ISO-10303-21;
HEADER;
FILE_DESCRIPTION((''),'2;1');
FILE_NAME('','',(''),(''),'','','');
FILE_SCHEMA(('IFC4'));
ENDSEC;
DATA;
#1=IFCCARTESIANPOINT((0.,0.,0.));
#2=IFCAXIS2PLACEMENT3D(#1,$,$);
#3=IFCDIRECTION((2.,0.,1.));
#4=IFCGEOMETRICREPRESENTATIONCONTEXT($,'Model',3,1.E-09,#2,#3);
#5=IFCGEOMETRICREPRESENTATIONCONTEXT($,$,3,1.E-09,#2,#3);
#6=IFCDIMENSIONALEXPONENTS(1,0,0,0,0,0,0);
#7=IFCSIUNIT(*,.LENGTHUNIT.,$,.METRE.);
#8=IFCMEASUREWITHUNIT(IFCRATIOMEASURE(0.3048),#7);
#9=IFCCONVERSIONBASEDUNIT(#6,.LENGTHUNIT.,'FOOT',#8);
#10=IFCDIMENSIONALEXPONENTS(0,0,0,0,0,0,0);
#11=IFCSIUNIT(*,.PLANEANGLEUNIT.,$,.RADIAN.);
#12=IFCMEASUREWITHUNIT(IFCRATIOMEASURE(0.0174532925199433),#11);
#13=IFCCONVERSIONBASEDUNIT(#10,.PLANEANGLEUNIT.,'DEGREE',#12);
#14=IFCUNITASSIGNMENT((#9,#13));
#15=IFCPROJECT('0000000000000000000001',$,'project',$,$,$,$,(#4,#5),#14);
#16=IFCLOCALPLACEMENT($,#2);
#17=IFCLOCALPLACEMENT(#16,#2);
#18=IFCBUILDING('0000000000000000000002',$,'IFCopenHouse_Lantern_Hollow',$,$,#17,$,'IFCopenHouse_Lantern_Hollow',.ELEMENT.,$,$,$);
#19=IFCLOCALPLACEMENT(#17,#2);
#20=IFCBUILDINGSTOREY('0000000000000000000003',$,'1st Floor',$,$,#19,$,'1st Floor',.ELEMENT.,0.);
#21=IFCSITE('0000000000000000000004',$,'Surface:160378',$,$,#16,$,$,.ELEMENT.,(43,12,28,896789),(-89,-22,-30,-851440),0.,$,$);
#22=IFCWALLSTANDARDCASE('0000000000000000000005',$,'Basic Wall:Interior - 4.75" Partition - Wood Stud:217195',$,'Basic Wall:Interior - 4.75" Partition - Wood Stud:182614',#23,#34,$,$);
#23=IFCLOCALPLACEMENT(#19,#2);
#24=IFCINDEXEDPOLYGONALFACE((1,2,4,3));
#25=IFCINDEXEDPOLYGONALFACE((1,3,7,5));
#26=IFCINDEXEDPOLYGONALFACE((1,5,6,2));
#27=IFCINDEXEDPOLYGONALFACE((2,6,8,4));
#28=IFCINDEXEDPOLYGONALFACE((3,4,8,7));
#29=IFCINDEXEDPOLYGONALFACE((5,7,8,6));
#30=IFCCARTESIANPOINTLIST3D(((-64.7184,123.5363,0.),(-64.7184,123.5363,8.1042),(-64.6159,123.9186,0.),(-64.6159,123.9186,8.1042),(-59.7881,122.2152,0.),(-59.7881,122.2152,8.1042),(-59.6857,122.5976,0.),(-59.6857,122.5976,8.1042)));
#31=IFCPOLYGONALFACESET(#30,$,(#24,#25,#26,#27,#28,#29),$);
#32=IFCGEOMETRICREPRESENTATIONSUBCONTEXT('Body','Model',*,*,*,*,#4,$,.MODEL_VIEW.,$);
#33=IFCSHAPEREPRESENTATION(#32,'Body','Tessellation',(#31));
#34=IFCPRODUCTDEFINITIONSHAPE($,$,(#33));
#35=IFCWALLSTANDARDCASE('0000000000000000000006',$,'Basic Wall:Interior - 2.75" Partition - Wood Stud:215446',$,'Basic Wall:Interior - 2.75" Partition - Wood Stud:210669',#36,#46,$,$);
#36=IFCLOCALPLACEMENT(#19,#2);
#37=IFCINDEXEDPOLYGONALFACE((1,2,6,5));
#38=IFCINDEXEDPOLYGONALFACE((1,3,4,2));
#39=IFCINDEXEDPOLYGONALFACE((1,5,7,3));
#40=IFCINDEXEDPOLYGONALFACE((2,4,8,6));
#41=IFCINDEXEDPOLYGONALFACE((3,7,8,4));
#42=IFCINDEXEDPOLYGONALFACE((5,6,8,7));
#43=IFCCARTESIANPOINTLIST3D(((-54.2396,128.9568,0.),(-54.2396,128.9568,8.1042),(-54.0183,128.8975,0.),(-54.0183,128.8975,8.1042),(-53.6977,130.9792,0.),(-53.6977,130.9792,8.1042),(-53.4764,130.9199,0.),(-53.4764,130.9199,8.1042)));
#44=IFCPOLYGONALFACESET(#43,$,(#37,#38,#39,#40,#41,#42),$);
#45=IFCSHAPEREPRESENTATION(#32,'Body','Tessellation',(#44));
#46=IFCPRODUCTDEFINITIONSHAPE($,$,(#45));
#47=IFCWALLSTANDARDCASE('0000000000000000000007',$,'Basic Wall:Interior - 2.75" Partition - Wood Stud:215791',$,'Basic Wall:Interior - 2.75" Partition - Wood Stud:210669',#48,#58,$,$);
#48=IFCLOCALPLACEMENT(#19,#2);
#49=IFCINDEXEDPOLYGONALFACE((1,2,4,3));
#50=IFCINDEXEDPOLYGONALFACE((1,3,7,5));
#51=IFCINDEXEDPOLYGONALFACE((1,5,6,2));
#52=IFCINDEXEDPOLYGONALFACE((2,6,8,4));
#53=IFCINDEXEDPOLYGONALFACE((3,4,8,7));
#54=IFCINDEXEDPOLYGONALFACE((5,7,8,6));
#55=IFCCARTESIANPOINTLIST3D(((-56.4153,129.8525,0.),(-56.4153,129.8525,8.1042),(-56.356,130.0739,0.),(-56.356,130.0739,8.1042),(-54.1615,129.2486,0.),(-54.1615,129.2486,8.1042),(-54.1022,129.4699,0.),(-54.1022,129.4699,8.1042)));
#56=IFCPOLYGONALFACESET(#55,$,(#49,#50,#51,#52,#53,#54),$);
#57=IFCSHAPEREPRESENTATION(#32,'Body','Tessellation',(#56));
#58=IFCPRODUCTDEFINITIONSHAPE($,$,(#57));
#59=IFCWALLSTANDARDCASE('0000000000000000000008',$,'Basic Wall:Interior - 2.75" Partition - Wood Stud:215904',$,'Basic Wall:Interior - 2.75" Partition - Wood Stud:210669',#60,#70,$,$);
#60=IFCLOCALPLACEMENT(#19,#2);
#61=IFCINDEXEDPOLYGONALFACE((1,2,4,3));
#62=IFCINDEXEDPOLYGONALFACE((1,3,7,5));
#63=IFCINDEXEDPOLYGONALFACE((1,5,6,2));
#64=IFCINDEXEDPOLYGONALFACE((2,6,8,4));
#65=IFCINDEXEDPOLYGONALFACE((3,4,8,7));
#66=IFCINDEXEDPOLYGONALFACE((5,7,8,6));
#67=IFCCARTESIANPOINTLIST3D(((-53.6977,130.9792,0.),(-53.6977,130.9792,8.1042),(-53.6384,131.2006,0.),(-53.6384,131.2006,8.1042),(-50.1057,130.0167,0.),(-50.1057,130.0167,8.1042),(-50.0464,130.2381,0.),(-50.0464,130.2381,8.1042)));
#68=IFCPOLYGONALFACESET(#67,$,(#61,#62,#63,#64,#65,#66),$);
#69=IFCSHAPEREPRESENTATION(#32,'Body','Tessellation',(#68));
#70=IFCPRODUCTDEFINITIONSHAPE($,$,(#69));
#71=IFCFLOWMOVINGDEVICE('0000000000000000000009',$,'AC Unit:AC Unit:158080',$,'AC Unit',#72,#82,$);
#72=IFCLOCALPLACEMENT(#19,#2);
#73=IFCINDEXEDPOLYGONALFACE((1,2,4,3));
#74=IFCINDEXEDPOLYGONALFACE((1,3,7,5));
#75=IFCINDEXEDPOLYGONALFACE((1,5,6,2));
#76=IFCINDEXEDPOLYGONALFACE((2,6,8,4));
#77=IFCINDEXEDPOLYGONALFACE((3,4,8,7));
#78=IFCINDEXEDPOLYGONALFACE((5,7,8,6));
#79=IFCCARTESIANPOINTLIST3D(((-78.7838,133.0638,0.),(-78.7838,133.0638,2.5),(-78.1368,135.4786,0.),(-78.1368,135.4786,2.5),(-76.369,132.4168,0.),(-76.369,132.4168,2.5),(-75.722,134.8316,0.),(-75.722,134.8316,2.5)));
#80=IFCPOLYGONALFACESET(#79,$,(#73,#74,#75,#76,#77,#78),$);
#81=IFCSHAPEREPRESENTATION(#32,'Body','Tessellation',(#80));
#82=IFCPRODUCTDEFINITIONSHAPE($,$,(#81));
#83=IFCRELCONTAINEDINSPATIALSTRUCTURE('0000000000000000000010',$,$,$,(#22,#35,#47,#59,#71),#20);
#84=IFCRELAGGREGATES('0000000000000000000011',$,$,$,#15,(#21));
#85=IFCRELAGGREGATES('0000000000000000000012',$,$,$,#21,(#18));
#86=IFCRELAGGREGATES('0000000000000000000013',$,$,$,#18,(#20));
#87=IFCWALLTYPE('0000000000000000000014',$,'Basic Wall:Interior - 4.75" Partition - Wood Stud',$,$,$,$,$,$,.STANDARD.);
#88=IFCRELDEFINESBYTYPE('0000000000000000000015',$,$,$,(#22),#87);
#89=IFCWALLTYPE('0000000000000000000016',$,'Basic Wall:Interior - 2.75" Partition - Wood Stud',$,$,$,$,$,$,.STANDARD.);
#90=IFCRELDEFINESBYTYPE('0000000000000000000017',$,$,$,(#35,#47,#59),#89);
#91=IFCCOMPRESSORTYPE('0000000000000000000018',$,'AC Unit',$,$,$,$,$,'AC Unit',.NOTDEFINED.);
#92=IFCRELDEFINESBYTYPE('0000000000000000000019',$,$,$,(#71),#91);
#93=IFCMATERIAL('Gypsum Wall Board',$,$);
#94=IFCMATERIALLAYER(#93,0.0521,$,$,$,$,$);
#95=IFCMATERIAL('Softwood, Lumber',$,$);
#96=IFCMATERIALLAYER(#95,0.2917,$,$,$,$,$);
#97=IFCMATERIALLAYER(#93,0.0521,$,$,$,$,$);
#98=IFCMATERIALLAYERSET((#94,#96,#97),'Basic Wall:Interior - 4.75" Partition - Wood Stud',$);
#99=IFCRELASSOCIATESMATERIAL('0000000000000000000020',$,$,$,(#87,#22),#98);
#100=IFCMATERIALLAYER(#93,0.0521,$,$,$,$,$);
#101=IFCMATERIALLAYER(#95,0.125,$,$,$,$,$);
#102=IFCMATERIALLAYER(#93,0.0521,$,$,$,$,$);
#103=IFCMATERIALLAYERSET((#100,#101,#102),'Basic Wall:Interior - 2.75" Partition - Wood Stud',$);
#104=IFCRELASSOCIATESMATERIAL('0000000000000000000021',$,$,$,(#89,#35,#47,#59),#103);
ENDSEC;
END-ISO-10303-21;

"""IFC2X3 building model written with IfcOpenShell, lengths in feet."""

from ifc_helpers import new_model, entity, si_unit, converted_unit, direction, frame, frame_2d, origin, place, context, subcontext, project, spatial, rectangle, extrude, source, transform, mapped, material, layer, layer_set, layer_usage, type_object, type_shapes, element, save


model = new_model("IFC2X3")

# Units and contexts
model_context = context("Model", 3, precision=1e-09, world=origin(), true_north=direction((2.0, 0.0, 1.0)))
context_of_model = context(None, 3, precision=1e-09, world=origin(), true_north=direction((2.0, 0.0, 1.0)))
body_context = subcontext(model_context, "Body", "Model", "MODEL_VIEW")
ifc_project = project(units=[converted_unit("LENGTHUNIT", "FOOT", entity("IfcRatioMeasure", 0.3048), si_unit("LENGTHUNIT", "METRE"), dimensions=[1, 0, 0, 0, 0, 0, 0]), converted_unit("PLANEANGLEUNIT", "DEGREE", entity("IfcRatioMeasure", 0.0174532925199433), si_unit("PLANEANGLEUNIT", "RADIAN"), dimensions=[0, 0, 0, 0, 0, 0, 0])], contexts=[model_context, context_of_model])

# Site, building, storey
site_placement = place(None, origin())
site = spatial("IfcSite", under=ifc_project, at=site_placement, Name="Surface:160378", CompositionType="ELEMENT", RefLatitude=(43, 12, 28, 896789), RefLongitude=(-89, -22, -30, -851440), RefElevation=0.0)
building_placement = place(site_placement, origin())
building = spatial("IfcBuilding", under=site, at=building_placement, Name="IFCopenHouse_Lantern_Hollow", LongName="IFCopenHouse_Lantern_Hollow", CompositionType="ELEMENT")
storey_placement = place(building_placement, origin())
storey = spatial("IfcBuildingStorey", under=building, at=storey_placement, Name="1st Floor", LongName="1st Floor", CompositionType="ELEMENT", Elevation=0.0)

# Shared definitions
ifc_material_1 = material(Name="Softwood, Lumber")

# Shared definitions
ifc_material_2 = material(Name="Gypsum Wall Board")

# Shared definitions
ifc_layer_1 = layer(ifc_material_2, 0.0521)
ifc_layer_2 = layer(ifc_material_1, 0.2917)
ifc_layer_3 = layer(ifc_material_2, 0.0521)
ifc_layer_set_1 = layer_set([ifc_layer_1, ifc_layer_2, ifc_layer_3], Name="Basic Wall:Interior - 4.75\" Partition - Wood Stud")
wall_type_1 = type_object("IfcWallType", Name="Basic Wall:Interior - 4.75\" Partition - Wood Stud", PredefinedType="STANDARD", material=ifc_layer_set_1)

# Walls
ifc_layer_usage_1 = layer_usage(ifc_layer_set_1, "AXIS2", "NEGATIVE", 0.1979)
wall_1_placement = place(storey_placement, frame((-59.7369, 122.4064, 0.0), z_axis=(0.0, 0.0, 1.0), x_axis=(-0.965926, 0.258819, 0.0)))
element("IfcWallStandardCase", 1, at=wall_1_placement, inside=storey, type_object=wall_type_1, material=ifc_layer_usage_1, Name="Basic Wall:Interior - 4.75\" Partition - Wood Stud:217195", ObjectType="Basic Wall:Interior - 4.75\" Partition - Wood Stud:182614", context=body_context, shape_type="SweptSolid", body=[
    extrude(rectangle(XDim=5.1042, YDim=0.3958, at=frame_2d((2.5521, 0.0), x_axis=(-1.0, 0.0))), origin(), (0.0, 0.0, 1.0), 8.1042),
])
ifc_layer_4 = layer(ifc_material_2, 0.0521)
ifc_layer_5 = layer(ifc_material_1, 0.125)
ifc_layer_6 = layer(ifc_material_2, 0.0521)
ifc_layer_set_2 = layer_set([ifc_layer_4, ifc_layer_5, ifc_layer_6], Name="Basic Wall:Interior - 2.75\" Partition - Wood Stud")
ifc_layer_usage_2 = layer_usage(ifc_layer_set_2, "AXIS2", "NEGATIVE", 0.1146)
wall_type_2 = type_object("IfcWallType", Name="Basic Wall:Interior - 2.75\" Partition - Wood Stud", PredefinedType="STANDARD", material=ifc_layer_set_2)
wall_2_placement = place(storey_placement, frame((-54.129, 128.9271, 0.0), z_axis=(0.0, 0.0, 1.0), x_axis=(0.258819, 0.965926, 0.0)))
element("IfcWallStandardCase", 2, at=wall_2_placement, inside=storey, type_object=wall_type_2, material=ifc_layer_usage_2, Name="Basic Wall:Interior - 2.75\" Partition - Wood Stud:215446", ObjectType="Basic Wall:Interior - 2.75\" Partition - Wood Stud:210669", context=body_context, shape_type="SweptSolid", body=[
    extrude(rectangle(XDim=2.0937, YDim=0.2292, at=frame_2d((1.0469, 0.0), x_axis=(-1.0, 0.0))), origin(), (0.0, 0.0, 1.0), 8.1042),
])
ifc_layer_usage_3 = layer_usage(ifc_layer_set_2, "AXIS2", "NEGATIVE", 0.1146)
wall_3_placement = place(storey_placement, frame((-56.3856, 129.9632, 0.0), z_axis=(0.0, 0.0, 1.0), x_axis=(0.965926, -0.258819, 0.0)))
element("IfcWallStandardCase", 3, at=wall_3_placement, inside=storey, type_object=wall_type_2, material=ifc_layer_usage_3, Name="Basic Wall:Interior - 2.75\" Partition - Wood Stud:215791", ObjectType="Basic Wall:Interior - 2.75\" Partition - Wood Stud:210669", context=body_context, shape_type="SweptSolid", body=[
    extrude(rectangle(XDim=2.3333, YDim=0.2292, at=frame_2d((1.1667, 0.0), x_axis=(-1.0, 0.0))), origin(), (0.0, 0.0, 1.0), 8.1042),
])
ifc_layer_usage_4 = layer_usage(ifc_layer_set_2, "AXIS2", "NEGATIVE", 0.1146)
wall_4_placement = place(storey_placement, frame((-53.6681, 131.0899, 0.0), z_axis=(0.0, 0.0, 1.0), x_axis=(0.965926, -0.258819, 0.0)))
element("IfcWallStandardCase", 4, at=wall_4_placement, inside=storey, type_object=wall_type_2, material=ifc_layer_usage_4, Name="Basic Wall:Interior - 2.75\" Partition - Wood Stud:215904", ObjectType="Basic Wall:Interior - 2.75\" Partition - Wood Stud:210669", context=body_context, shape_type="SweptSolid", body=[
    extrude(rectangle(XDim=3.7188, YDim=0.2292, at=frame_2d((1.8594, 0.0), x_axis=(-1.0, 0.0))), origin(), (0.0, 0.0, 1.0), 8.1042),
])

# Flow moving device
compressor_type = type_object("IfcCompressorType", Name="AC Unit", ElementType="AC Unit", PredefinedType="NOTDEFINED")
shared_shape_1 = source(origin(), body_context, "Body", "SweptSolid", [
    extrude(rectangle(XDim=2.5, YDim=2.5, at=frame_2d((0.0, 0.0), x_axis=(1.0, 0.0))), frame((-77.2529, 133.9477, 0.0), z_axis=(0.0, 0.0, 1.0), x_axis=(0.258819, 0.965926, 0.0)), (0.0, 0.0, 1.0), 2.5),
])
type_shapes(compressor_type, [shared_shape_1])
flow_moving_device_placement = place(storey_placement, origin())
element("IfcFlowMovingDevice", 5, at=flow_moving_device_placement, inside=storey, type_object=compressor_type, Name="AC Unit:AC Unit:158080", ObjectType="AC Unit", context=body_context, shape_type="MappedRepresentation", body=[
    mapped(shared_shape_1, transform((0.0, 0.0, 0.0), scale=1.0)),
])

save(model, "model.ifc")
